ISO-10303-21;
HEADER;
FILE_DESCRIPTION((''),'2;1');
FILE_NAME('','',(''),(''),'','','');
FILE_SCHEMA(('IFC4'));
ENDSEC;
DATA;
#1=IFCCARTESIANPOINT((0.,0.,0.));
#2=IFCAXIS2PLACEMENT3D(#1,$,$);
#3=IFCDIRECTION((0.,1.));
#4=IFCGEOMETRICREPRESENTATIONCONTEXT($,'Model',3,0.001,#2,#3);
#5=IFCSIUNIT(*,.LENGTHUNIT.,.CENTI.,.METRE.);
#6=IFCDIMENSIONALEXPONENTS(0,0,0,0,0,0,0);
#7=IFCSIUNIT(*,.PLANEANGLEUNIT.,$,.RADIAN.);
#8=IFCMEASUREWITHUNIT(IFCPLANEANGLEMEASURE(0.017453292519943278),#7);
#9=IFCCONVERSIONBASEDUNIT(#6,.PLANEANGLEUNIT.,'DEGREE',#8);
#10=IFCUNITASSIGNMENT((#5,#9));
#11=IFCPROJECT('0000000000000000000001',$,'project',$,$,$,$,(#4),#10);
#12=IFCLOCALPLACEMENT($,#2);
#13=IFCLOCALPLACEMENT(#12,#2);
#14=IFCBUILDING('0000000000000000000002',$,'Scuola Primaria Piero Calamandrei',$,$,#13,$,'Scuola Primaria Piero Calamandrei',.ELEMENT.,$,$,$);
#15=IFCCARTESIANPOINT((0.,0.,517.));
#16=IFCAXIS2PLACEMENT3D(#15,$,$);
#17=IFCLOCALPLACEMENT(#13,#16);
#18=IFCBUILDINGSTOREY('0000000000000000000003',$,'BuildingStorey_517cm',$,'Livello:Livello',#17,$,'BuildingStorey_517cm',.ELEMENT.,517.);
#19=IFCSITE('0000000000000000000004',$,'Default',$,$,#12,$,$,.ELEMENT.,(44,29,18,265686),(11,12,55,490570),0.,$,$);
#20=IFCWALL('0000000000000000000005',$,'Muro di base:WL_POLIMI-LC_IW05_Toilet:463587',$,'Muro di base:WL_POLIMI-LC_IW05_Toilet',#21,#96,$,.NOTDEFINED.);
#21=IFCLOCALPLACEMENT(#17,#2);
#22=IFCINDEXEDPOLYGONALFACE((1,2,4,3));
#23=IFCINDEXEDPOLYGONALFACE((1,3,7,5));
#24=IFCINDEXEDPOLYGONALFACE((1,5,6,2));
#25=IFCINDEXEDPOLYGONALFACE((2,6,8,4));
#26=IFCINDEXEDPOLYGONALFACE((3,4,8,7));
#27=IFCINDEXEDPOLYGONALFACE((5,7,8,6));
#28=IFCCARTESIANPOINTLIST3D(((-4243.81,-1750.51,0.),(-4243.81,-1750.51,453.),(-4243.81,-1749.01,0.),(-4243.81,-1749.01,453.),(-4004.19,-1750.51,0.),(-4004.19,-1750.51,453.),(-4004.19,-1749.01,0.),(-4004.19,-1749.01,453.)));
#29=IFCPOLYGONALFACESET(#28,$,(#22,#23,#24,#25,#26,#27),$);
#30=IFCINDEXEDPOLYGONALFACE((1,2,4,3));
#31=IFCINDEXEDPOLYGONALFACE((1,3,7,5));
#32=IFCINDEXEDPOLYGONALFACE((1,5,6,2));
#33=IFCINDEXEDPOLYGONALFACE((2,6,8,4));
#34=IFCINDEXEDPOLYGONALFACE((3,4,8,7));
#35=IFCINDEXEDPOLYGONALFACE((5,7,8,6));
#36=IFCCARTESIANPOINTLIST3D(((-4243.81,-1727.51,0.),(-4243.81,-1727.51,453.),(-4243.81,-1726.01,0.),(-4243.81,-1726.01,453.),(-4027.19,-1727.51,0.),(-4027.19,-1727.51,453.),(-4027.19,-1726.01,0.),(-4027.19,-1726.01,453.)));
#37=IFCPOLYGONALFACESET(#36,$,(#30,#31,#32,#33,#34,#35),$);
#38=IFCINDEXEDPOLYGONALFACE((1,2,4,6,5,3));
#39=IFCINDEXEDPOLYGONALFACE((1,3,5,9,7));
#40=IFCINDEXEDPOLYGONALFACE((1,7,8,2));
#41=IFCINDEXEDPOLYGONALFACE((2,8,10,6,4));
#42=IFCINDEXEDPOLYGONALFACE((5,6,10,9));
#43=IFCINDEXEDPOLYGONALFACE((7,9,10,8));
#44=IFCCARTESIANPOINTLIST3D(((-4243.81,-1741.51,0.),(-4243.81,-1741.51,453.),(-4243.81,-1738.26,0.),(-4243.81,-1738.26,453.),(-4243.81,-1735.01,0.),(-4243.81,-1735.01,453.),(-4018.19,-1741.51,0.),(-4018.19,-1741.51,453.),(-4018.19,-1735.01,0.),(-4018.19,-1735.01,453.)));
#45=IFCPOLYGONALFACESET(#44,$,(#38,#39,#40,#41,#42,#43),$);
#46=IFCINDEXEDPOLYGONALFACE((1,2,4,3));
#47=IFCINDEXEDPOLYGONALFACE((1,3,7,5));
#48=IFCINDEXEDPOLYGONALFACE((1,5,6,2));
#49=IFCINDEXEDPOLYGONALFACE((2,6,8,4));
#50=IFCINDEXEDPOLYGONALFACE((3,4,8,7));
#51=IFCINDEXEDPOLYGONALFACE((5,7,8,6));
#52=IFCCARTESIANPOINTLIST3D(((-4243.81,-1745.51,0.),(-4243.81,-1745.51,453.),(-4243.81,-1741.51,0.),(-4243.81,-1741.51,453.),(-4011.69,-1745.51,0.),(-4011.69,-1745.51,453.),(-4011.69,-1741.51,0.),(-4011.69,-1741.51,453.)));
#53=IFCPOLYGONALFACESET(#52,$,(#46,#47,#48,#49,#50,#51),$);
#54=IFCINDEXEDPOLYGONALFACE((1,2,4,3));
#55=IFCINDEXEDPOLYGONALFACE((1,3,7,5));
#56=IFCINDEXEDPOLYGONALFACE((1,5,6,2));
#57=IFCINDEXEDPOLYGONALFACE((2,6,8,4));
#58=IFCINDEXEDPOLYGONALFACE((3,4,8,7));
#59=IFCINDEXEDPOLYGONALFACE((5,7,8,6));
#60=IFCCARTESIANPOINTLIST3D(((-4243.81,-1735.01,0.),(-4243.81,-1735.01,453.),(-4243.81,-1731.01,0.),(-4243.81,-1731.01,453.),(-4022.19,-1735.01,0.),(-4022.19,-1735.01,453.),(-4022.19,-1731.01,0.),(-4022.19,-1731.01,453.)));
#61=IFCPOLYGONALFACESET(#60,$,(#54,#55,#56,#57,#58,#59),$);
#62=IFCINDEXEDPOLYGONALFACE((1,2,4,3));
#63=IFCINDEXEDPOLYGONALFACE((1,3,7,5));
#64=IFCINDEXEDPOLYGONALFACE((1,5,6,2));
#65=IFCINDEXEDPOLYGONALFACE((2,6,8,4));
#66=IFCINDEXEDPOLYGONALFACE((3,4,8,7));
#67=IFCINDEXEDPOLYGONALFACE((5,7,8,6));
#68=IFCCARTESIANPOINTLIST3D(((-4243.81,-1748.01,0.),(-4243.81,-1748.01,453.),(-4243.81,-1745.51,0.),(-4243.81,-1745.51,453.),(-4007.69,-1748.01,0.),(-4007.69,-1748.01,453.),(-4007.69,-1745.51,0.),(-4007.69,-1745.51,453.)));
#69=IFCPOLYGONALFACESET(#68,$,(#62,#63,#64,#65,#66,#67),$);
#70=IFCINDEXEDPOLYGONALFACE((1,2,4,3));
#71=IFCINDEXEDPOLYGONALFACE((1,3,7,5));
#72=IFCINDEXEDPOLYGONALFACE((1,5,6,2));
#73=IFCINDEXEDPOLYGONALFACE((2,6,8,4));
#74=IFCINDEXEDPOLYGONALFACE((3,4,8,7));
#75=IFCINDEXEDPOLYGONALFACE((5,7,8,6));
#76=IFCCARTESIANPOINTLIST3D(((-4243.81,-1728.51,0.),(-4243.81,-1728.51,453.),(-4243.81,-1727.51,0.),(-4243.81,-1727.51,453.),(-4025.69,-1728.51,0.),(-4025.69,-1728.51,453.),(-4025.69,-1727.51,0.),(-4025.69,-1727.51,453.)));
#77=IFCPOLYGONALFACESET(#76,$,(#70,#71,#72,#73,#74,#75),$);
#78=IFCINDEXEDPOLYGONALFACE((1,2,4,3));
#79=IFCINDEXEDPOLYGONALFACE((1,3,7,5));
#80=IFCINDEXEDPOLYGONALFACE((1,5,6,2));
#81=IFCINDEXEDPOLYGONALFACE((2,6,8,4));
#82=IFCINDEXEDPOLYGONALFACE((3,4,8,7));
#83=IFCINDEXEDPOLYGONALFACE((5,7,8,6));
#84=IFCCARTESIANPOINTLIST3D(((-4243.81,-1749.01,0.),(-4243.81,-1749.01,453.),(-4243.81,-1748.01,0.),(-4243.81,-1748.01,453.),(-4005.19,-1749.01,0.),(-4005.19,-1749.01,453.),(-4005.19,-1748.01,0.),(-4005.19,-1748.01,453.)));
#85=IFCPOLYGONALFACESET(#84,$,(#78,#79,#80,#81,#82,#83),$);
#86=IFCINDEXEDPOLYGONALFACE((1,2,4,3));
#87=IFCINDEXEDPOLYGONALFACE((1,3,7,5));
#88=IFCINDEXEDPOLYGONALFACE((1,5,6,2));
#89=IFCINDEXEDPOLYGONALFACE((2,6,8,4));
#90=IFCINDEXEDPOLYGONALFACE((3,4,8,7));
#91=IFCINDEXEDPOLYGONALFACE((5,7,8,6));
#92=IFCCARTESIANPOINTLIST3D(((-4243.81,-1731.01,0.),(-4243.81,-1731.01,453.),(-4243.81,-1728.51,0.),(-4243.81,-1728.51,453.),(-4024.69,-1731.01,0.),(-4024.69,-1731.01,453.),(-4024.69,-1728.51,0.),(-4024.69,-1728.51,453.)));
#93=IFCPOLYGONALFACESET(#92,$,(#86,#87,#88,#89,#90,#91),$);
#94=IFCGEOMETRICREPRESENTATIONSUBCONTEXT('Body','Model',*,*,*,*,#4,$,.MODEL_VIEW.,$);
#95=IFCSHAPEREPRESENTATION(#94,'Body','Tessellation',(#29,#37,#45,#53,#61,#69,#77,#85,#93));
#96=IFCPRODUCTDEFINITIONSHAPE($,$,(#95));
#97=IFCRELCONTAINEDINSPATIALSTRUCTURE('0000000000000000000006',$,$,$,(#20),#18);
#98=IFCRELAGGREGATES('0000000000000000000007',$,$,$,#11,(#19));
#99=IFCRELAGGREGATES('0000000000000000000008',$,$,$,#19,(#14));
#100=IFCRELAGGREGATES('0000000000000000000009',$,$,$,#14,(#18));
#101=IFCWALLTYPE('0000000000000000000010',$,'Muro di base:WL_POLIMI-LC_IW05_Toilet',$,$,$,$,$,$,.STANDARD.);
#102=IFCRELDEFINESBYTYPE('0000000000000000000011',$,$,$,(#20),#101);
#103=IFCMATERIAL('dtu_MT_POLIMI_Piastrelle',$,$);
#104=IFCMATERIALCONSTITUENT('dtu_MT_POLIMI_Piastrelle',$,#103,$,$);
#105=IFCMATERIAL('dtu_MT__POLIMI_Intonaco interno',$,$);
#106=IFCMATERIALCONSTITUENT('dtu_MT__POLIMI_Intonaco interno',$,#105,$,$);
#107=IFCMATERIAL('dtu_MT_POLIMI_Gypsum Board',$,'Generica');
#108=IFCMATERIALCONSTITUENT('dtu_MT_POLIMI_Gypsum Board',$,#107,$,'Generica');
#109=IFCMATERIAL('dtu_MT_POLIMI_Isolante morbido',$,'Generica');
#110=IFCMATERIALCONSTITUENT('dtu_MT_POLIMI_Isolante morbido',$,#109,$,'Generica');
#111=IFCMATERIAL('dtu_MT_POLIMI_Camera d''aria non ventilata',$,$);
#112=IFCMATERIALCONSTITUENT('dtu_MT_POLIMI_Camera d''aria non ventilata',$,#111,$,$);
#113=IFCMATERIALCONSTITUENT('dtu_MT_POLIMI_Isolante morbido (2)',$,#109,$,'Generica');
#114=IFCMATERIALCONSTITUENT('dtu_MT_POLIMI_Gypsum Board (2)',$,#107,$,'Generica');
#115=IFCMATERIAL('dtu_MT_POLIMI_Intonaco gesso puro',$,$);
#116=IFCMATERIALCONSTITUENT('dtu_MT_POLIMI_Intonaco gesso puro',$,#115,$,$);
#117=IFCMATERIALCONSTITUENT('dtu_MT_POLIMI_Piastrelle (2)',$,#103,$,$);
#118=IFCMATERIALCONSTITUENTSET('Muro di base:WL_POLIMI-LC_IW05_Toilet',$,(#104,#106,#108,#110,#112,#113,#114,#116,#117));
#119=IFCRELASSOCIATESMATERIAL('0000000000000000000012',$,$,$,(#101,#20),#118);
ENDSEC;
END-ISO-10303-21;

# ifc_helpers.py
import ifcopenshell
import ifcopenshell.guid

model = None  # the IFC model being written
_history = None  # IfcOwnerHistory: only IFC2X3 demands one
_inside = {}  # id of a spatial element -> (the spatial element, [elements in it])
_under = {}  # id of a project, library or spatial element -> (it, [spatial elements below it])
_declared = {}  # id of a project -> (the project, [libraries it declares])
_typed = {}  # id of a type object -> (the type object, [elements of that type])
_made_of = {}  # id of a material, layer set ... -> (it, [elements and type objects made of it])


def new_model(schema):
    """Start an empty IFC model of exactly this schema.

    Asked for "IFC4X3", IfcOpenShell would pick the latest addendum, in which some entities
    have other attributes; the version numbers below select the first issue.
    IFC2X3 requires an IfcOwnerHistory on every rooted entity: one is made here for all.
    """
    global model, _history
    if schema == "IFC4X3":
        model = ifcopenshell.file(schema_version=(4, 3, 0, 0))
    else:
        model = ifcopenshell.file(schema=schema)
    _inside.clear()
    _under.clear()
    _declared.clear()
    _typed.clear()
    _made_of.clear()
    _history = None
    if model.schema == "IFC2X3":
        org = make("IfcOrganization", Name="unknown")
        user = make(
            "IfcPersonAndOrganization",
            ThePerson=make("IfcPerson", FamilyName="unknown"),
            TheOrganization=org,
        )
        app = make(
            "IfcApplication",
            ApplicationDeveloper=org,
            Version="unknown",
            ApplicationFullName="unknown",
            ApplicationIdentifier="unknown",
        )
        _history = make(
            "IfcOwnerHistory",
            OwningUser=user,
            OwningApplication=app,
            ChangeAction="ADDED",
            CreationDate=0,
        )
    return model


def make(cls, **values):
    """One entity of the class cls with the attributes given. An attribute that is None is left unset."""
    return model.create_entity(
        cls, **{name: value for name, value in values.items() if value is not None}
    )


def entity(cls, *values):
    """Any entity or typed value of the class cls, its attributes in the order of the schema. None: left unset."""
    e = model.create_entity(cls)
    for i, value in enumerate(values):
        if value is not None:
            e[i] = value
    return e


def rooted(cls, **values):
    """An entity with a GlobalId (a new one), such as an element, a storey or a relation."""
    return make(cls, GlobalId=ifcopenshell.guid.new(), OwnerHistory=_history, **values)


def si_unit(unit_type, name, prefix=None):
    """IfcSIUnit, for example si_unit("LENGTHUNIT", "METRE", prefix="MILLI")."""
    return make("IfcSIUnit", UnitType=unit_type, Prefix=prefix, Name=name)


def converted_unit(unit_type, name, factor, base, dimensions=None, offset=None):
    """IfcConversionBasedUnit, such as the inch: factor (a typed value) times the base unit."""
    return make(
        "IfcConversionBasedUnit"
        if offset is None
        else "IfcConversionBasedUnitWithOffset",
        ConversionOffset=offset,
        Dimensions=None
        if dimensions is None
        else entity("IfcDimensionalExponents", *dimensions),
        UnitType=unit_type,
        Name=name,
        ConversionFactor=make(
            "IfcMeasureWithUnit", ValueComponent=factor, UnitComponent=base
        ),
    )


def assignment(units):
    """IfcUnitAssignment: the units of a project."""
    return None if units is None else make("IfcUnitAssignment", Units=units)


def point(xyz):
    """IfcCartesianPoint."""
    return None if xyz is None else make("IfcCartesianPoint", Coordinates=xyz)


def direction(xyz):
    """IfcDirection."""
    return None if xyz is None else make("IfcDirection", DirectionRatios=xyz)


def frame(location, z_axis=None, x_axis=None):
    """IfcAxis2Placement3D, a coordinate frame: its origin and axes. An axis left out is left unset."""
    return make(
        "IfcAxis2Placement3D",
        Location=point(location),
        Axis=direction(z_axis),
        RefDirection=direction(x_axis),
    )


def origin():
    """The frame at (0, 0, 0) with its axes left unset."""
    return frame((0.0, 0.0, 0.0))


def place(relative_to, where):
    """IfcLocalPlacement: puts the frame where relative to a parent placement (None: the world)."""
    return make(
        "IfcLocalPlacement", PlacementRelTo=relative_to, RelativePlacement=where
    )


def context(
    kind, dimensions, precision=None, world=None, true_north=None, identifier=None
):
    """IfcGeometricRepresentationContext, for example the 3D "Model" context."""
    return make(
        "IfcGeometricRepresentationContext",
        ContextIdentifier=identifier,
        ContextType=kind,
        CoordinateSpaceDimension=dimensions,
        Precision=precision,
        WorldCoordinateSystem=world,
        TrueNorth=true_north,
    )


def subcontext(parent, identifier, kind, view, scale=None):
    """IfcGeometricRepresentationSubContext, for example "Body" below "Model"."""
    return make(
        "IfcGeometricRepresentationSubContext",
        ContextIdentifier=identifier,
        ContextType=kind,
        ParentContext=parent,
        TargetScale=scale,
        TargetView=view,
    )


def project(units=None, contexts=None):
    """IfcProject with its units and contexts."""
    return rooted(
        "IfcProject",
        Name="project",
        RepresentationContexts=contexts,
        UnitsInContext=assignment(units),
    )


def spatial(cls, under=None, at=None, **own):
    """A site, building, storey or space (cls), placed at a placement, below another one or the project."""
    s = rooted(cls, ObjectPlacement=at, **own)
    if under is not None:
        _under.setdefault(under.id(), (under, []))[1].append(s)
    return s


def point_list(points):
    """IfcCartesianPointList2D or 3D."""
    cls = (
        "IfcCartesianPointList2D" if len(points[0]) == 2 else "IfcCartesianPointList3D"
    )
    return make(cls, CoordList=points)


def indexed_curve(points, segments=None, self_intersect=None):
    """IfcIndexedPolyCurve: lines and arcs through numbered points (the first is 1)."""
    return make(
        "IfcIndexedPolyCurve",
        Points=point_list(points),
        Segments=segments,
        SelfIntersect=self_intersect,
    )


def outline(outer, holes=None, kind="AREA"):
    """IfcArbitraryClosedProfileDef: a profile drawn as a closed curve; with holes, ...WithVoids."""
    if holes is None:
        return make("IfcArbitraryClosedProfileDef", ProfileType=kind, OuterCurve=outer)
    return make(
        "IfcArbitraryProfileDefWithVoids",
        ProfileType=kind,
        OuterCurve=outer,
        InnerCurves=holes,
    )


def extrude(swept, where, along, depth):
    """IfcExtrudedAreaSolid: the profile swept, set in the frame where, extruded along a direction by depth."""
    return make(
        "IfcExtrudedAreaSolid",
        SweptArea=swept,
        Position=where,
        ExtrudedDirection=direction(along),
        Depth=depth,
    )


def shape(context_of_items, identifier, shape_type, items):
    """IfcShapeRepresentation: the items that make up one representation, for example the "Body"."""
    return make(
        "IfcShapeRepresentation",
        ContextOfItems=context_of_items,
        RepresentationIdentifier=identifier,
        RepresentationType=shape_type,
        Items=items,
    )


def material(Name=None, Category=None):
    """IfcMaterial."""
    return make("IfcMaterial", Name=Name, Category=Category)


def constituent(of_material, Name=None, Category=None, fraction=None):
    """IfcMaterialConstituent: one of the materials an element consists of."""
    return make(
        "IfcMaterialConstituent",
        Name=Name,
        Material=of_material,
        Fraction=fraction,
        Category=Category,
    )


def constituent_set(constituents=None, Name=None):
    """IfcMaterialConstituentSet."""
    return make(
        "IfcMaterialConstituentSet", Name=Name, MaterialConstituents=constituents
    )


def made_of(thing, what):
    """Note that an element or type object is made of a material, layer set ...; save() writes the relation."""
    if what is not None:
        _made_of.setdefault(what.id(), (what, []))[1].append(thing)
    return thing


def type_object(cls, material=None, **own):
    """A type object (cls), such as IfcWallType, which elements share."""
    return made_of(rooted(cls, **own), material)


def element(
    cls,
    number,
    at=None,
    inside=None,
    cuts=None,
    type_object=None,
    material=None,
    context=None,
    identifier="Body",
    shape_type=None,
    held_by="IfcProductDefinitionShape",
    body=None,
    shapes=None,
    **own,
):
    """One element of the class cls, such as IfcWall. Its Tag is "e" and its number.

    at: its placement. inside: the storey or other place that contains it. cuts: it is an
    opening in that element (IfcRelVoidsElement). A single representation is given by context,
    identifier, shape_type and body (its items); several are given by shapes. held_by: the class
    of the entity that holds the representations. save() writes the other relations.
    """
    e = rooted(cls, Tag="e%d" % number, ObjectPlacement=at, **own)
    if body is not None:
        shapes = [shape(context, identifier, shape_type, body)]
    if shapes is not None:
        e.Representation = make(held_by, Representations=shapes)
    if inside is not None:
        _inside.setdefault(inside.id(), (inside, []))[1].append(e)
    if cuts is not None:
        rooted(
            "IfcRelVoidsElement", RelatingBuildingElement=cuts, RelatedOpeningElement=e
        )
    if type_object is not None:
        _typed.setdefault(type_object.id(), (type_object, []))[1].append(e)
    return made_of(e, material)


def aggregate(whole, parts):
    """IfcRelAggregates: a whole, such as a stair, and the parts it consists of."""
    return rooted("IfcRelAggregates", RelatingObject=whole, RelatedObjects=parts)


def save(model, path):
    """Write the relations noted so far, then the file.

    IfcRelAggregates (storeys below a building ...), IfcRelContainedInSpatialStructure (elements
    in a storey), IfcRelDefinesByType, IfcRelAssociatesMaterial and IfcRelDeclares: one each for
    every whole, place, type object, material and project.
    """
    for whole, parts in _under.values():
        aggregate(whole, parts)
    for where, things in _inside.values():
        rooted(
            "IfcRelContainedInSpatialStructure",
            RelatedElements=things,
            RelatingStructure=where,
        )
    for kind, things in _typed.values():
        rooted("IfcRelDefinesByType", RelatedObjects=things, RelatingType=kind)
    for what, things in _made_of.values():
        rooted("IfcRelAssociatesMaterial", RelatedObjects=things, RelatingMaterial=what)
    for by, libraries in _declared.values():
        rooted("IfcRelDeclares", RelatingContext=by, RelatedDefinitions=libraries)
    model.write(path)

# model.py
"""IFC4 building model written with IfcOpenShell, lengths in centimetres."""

from ifc_helpers import new_model, entity, si_unit, converted_unit, direction, frame, origin, place, context, subcontext, project, spatial, indexed_curve, outline, extrude, material, constituent, constituent_set, type_object, element, save


model = new_model("IFC4")

# Units and contexts
model_context = context("Model", 3, precision=0.001, world=origin(), true_north=direction((0.0, 1.0)))
body_context = subcontext(model_context, "Body", "Model", "MODEL_VIEW")
ifc_project = project(units=[si_unit("LENGTHUNIT", "METRE", prefix="CENTI"), converted_unit("PLANEANGLEUNIT", "DEGREE", entity("IfcPlaneAngleMeasure", 0.017453292519943278), si_unit("PLANEANGLEUNIT", "RADIAN"), dimensions=[0, 0, 0, 0, 0, 0, 0])], contexts=[model_context])

# Site, building, storey
site_placement = place(None, origin())
site = spatial("IfcSite", under=ifc_project, at=site_placement, Name="Default", CompositionType="ELEMENT", RefLatitude=(44, 29, 18, 265686), RefLongitude=(11, 12, 55, 490570), RefElevation=0.0)
building_placement = place(site_placement, origin())
building = spatial("IfcBuilding", under=site, at=building_placement, Name="Scuola Primaria Piero Calamandrei", LongName="Scuola Primaria Piero Calamandrei", CompositionType="ELEMENT")
storey_placement = place(building_placement, frame((0.0, 0.0, 517.0)))
storey = spatial("IfcBuildingStorey", under=building, at=storey_placement, Name="BuildingStorey_517cm", ObjectType="Livello:Livello", LongName="BuildingStorey_517cm", CompositionType="ELEMENT", Elevation=517.0)

# Shared definitions
ifc_material_1 = material(Name="dtu_MT_POLIMI_Isolante morbido", Category="Generica")
ifc_material_2 = material(Name="dtu_MT_POLIMI_Gypsum Board", Category="Generica")
ifc_material_3 = material(Name="dtu_MT__POLIMI_Intonaco interno")

# Shared definitions
ifc_material_4 = material(Name="dtu_MT_POLIMI_Camera d'aria non ventilata")
ifc_material_5 = material(Name="dtu_MT_POLIMI_Intonaco gesso puro")
ifc_material_6 = material(Name="dtu_MT_POLIMI_Piastrelle")

# Wall
ifc_constituent_1 = constituent(ifc_material_6, Name="dtu_MT_POLIMI_Piastrelle")
ifc_constituent_2 = constituent(ifc_material_3, Name="dtu_MT__POLIMI_Intonaco interno")
ifc_constituent_3 = constituent(ifc_material_2, Name="dtu_MT_POLIMI_Gypsum Board", Category="Generica")
ifc_constituent_4 = constituent(ifc_material_1, Name="dtu_MT_POLIMI_Isolante morbido", Category="Generica")
ifc_constituent_5 = constituent(ifc_material_4, Name="dtu_MT_POLIMI_Camera d'aria non ventilata")
ifc_constituent_6 = constituent(ifc_material_1, Name="dtu_MT_POLIMI_Isolante morbido (2)", Category="Generica")
ifc_constituent_7 = constituent(ifc_material_2, Name="dtu_MT_POLIMI_Gypsum Board (2)", Category="Generica")
ifc_constituent_8 = constituent(ifc_material_5, Name="dtu_MT_POLIMI_Intonaco gesso puro")
ifc_constituent_9 = constituent(ifc_material_6, Name="dtu_MT_POLIMI_Piastrelle (2)")
ifc_constituent_set_1 = constituent_set(constituents=[ifc_constituent_1, ifc_constituent_2, ifc_constituent_3, ifc_constituent_4, ifc_constituent_5, ifc_constituent_6, ifc_constituent_7, ifc_constituent_8, ifc_constituent_9], Name="Muro di base:WL_POLIMI-LC_IW05_Toilet")
wall_type_1 = type_object("IfcWallType", Name="Muro di base:WL_POLIMI-LC_IW05_Toilet", PredefinedType="STANDARD", material=ifc_constituent_set_1)
wall_1_placement = place(storey_placement, frame((-4027.19, -1738.26, 0.0), z_axis=(0.0, 0.0, 1.0), x_axis=(-1.0, 0.0, 0.0)))
element("IfcWall", 1, at=wall_1_placement, inside=storey, type_object=wall_type_1, material=ifc_constituent_set_1, Name="Muro di base:WL_POLIMI-LC_IW05_Toilet:463587", ObjectType="Muro di base:WL_POLIMI-LC_IW05_Toilet", PredefinedType="NOTDEFINED", context=body_context, shape_type="SweptSolid", body=[
    extrude(outline(indexed_curve([(-0.75, -119.81), (0.75, -119.81), (0.75, 119.81), (-0.75, 119.81), (-0.75, -119.81)], self_intersect=False)), frame((96.81, 11.5, 0.0), z_axis=(0.0, 0.0, 1.0), x_axis=(0.0, -1.0, 0.0)), (0.0, 0.0, 1.0), 453.0),
    extrude(outline(indexed_curve([(-0.75, -108.31), (0.75, -108.31), (0.75, 108.31), (-0.75, 108.31), (-0.75, -108.31)], self_intersect=False)), frame((108.31, -11.5, 0.0), z_axis=(0.0, 0.0, 1.0), x_axis=(0.0, 1.0, 0.0)), (0.0, 0.0, 1.0), 453.0),
    extrude(outline(indexed_curve([(-135.37, -3.25), (90.25, -3.25), (90.25, 0.0), (90.25, 3.25), (-135.37, 3.25), (-135.37, -3.25)], self_intersect=False)), frame((126.37, 0.0, 0.0)), (0.0, 0.0, 1.0), 453.0),
    extrude(outline(indexed_curve([(-116.06, -2.0), (116.06, -2.0), (116.06, 2.0), (-116.06, 2.0), (-116.06, -2.0)], self_intersect=False)), frame((100.56, 5.25, 0.0)), (0.0, 0.0, 1.0), 453.0),
    extrude(outline(indexed_curve([(-110.81, -2.0), (110.81, -2.0), (110.81, 2.0), (-110.81, 2.0), (-110.81, -2.0)], self_intersect=False)), frame((105.81, -5.25, 0.0)), (0.0, 0.0, 1.0), 453.0),
    extrude(outline(indexed_curve([(-118.06, -1.25), (118.06, -1.25), (118.06, 1.25), (-118.06, 1.25), (-118.06, -1.25)], self_intersect=False)), frame((98.56, 8.5, 0.0)), (0.0, 0.0, 1.0), 453.0),
    extrude(outline(indexed_curve([(-109.06, -0.5), (109.06, -0.5), (109.06, 0.5), (-109.06, 0.5), (-109.06, -0.5)], self_intersect=False)), frame((107.56, -10.25, 0.0)), (0.0, 0.0, 1.0), 453.0),
    extrude(outline(indexed_curve([(-119.31, -0.5), (119.31, -0.5), (119.31, 0.5), (-119.31, 0.5), (-119.31, -0.5)], self_intersect=False)), frame((97.31, 10.25, 0.0)), (0.0, 0.0, 1.0), 453.0),
    extrude(outline(indexed_curve([(-109.56, -1.25), (109.56, -1.25), (109.56, 1.25), (-109.56, 1.25), (-109.56, -1.25)], self_intersect=False)), frame((107.06, -8.5, 0.0)), (0.0, 0.0, 1.0), 453.0),
])

save(model, "model.ifc")
